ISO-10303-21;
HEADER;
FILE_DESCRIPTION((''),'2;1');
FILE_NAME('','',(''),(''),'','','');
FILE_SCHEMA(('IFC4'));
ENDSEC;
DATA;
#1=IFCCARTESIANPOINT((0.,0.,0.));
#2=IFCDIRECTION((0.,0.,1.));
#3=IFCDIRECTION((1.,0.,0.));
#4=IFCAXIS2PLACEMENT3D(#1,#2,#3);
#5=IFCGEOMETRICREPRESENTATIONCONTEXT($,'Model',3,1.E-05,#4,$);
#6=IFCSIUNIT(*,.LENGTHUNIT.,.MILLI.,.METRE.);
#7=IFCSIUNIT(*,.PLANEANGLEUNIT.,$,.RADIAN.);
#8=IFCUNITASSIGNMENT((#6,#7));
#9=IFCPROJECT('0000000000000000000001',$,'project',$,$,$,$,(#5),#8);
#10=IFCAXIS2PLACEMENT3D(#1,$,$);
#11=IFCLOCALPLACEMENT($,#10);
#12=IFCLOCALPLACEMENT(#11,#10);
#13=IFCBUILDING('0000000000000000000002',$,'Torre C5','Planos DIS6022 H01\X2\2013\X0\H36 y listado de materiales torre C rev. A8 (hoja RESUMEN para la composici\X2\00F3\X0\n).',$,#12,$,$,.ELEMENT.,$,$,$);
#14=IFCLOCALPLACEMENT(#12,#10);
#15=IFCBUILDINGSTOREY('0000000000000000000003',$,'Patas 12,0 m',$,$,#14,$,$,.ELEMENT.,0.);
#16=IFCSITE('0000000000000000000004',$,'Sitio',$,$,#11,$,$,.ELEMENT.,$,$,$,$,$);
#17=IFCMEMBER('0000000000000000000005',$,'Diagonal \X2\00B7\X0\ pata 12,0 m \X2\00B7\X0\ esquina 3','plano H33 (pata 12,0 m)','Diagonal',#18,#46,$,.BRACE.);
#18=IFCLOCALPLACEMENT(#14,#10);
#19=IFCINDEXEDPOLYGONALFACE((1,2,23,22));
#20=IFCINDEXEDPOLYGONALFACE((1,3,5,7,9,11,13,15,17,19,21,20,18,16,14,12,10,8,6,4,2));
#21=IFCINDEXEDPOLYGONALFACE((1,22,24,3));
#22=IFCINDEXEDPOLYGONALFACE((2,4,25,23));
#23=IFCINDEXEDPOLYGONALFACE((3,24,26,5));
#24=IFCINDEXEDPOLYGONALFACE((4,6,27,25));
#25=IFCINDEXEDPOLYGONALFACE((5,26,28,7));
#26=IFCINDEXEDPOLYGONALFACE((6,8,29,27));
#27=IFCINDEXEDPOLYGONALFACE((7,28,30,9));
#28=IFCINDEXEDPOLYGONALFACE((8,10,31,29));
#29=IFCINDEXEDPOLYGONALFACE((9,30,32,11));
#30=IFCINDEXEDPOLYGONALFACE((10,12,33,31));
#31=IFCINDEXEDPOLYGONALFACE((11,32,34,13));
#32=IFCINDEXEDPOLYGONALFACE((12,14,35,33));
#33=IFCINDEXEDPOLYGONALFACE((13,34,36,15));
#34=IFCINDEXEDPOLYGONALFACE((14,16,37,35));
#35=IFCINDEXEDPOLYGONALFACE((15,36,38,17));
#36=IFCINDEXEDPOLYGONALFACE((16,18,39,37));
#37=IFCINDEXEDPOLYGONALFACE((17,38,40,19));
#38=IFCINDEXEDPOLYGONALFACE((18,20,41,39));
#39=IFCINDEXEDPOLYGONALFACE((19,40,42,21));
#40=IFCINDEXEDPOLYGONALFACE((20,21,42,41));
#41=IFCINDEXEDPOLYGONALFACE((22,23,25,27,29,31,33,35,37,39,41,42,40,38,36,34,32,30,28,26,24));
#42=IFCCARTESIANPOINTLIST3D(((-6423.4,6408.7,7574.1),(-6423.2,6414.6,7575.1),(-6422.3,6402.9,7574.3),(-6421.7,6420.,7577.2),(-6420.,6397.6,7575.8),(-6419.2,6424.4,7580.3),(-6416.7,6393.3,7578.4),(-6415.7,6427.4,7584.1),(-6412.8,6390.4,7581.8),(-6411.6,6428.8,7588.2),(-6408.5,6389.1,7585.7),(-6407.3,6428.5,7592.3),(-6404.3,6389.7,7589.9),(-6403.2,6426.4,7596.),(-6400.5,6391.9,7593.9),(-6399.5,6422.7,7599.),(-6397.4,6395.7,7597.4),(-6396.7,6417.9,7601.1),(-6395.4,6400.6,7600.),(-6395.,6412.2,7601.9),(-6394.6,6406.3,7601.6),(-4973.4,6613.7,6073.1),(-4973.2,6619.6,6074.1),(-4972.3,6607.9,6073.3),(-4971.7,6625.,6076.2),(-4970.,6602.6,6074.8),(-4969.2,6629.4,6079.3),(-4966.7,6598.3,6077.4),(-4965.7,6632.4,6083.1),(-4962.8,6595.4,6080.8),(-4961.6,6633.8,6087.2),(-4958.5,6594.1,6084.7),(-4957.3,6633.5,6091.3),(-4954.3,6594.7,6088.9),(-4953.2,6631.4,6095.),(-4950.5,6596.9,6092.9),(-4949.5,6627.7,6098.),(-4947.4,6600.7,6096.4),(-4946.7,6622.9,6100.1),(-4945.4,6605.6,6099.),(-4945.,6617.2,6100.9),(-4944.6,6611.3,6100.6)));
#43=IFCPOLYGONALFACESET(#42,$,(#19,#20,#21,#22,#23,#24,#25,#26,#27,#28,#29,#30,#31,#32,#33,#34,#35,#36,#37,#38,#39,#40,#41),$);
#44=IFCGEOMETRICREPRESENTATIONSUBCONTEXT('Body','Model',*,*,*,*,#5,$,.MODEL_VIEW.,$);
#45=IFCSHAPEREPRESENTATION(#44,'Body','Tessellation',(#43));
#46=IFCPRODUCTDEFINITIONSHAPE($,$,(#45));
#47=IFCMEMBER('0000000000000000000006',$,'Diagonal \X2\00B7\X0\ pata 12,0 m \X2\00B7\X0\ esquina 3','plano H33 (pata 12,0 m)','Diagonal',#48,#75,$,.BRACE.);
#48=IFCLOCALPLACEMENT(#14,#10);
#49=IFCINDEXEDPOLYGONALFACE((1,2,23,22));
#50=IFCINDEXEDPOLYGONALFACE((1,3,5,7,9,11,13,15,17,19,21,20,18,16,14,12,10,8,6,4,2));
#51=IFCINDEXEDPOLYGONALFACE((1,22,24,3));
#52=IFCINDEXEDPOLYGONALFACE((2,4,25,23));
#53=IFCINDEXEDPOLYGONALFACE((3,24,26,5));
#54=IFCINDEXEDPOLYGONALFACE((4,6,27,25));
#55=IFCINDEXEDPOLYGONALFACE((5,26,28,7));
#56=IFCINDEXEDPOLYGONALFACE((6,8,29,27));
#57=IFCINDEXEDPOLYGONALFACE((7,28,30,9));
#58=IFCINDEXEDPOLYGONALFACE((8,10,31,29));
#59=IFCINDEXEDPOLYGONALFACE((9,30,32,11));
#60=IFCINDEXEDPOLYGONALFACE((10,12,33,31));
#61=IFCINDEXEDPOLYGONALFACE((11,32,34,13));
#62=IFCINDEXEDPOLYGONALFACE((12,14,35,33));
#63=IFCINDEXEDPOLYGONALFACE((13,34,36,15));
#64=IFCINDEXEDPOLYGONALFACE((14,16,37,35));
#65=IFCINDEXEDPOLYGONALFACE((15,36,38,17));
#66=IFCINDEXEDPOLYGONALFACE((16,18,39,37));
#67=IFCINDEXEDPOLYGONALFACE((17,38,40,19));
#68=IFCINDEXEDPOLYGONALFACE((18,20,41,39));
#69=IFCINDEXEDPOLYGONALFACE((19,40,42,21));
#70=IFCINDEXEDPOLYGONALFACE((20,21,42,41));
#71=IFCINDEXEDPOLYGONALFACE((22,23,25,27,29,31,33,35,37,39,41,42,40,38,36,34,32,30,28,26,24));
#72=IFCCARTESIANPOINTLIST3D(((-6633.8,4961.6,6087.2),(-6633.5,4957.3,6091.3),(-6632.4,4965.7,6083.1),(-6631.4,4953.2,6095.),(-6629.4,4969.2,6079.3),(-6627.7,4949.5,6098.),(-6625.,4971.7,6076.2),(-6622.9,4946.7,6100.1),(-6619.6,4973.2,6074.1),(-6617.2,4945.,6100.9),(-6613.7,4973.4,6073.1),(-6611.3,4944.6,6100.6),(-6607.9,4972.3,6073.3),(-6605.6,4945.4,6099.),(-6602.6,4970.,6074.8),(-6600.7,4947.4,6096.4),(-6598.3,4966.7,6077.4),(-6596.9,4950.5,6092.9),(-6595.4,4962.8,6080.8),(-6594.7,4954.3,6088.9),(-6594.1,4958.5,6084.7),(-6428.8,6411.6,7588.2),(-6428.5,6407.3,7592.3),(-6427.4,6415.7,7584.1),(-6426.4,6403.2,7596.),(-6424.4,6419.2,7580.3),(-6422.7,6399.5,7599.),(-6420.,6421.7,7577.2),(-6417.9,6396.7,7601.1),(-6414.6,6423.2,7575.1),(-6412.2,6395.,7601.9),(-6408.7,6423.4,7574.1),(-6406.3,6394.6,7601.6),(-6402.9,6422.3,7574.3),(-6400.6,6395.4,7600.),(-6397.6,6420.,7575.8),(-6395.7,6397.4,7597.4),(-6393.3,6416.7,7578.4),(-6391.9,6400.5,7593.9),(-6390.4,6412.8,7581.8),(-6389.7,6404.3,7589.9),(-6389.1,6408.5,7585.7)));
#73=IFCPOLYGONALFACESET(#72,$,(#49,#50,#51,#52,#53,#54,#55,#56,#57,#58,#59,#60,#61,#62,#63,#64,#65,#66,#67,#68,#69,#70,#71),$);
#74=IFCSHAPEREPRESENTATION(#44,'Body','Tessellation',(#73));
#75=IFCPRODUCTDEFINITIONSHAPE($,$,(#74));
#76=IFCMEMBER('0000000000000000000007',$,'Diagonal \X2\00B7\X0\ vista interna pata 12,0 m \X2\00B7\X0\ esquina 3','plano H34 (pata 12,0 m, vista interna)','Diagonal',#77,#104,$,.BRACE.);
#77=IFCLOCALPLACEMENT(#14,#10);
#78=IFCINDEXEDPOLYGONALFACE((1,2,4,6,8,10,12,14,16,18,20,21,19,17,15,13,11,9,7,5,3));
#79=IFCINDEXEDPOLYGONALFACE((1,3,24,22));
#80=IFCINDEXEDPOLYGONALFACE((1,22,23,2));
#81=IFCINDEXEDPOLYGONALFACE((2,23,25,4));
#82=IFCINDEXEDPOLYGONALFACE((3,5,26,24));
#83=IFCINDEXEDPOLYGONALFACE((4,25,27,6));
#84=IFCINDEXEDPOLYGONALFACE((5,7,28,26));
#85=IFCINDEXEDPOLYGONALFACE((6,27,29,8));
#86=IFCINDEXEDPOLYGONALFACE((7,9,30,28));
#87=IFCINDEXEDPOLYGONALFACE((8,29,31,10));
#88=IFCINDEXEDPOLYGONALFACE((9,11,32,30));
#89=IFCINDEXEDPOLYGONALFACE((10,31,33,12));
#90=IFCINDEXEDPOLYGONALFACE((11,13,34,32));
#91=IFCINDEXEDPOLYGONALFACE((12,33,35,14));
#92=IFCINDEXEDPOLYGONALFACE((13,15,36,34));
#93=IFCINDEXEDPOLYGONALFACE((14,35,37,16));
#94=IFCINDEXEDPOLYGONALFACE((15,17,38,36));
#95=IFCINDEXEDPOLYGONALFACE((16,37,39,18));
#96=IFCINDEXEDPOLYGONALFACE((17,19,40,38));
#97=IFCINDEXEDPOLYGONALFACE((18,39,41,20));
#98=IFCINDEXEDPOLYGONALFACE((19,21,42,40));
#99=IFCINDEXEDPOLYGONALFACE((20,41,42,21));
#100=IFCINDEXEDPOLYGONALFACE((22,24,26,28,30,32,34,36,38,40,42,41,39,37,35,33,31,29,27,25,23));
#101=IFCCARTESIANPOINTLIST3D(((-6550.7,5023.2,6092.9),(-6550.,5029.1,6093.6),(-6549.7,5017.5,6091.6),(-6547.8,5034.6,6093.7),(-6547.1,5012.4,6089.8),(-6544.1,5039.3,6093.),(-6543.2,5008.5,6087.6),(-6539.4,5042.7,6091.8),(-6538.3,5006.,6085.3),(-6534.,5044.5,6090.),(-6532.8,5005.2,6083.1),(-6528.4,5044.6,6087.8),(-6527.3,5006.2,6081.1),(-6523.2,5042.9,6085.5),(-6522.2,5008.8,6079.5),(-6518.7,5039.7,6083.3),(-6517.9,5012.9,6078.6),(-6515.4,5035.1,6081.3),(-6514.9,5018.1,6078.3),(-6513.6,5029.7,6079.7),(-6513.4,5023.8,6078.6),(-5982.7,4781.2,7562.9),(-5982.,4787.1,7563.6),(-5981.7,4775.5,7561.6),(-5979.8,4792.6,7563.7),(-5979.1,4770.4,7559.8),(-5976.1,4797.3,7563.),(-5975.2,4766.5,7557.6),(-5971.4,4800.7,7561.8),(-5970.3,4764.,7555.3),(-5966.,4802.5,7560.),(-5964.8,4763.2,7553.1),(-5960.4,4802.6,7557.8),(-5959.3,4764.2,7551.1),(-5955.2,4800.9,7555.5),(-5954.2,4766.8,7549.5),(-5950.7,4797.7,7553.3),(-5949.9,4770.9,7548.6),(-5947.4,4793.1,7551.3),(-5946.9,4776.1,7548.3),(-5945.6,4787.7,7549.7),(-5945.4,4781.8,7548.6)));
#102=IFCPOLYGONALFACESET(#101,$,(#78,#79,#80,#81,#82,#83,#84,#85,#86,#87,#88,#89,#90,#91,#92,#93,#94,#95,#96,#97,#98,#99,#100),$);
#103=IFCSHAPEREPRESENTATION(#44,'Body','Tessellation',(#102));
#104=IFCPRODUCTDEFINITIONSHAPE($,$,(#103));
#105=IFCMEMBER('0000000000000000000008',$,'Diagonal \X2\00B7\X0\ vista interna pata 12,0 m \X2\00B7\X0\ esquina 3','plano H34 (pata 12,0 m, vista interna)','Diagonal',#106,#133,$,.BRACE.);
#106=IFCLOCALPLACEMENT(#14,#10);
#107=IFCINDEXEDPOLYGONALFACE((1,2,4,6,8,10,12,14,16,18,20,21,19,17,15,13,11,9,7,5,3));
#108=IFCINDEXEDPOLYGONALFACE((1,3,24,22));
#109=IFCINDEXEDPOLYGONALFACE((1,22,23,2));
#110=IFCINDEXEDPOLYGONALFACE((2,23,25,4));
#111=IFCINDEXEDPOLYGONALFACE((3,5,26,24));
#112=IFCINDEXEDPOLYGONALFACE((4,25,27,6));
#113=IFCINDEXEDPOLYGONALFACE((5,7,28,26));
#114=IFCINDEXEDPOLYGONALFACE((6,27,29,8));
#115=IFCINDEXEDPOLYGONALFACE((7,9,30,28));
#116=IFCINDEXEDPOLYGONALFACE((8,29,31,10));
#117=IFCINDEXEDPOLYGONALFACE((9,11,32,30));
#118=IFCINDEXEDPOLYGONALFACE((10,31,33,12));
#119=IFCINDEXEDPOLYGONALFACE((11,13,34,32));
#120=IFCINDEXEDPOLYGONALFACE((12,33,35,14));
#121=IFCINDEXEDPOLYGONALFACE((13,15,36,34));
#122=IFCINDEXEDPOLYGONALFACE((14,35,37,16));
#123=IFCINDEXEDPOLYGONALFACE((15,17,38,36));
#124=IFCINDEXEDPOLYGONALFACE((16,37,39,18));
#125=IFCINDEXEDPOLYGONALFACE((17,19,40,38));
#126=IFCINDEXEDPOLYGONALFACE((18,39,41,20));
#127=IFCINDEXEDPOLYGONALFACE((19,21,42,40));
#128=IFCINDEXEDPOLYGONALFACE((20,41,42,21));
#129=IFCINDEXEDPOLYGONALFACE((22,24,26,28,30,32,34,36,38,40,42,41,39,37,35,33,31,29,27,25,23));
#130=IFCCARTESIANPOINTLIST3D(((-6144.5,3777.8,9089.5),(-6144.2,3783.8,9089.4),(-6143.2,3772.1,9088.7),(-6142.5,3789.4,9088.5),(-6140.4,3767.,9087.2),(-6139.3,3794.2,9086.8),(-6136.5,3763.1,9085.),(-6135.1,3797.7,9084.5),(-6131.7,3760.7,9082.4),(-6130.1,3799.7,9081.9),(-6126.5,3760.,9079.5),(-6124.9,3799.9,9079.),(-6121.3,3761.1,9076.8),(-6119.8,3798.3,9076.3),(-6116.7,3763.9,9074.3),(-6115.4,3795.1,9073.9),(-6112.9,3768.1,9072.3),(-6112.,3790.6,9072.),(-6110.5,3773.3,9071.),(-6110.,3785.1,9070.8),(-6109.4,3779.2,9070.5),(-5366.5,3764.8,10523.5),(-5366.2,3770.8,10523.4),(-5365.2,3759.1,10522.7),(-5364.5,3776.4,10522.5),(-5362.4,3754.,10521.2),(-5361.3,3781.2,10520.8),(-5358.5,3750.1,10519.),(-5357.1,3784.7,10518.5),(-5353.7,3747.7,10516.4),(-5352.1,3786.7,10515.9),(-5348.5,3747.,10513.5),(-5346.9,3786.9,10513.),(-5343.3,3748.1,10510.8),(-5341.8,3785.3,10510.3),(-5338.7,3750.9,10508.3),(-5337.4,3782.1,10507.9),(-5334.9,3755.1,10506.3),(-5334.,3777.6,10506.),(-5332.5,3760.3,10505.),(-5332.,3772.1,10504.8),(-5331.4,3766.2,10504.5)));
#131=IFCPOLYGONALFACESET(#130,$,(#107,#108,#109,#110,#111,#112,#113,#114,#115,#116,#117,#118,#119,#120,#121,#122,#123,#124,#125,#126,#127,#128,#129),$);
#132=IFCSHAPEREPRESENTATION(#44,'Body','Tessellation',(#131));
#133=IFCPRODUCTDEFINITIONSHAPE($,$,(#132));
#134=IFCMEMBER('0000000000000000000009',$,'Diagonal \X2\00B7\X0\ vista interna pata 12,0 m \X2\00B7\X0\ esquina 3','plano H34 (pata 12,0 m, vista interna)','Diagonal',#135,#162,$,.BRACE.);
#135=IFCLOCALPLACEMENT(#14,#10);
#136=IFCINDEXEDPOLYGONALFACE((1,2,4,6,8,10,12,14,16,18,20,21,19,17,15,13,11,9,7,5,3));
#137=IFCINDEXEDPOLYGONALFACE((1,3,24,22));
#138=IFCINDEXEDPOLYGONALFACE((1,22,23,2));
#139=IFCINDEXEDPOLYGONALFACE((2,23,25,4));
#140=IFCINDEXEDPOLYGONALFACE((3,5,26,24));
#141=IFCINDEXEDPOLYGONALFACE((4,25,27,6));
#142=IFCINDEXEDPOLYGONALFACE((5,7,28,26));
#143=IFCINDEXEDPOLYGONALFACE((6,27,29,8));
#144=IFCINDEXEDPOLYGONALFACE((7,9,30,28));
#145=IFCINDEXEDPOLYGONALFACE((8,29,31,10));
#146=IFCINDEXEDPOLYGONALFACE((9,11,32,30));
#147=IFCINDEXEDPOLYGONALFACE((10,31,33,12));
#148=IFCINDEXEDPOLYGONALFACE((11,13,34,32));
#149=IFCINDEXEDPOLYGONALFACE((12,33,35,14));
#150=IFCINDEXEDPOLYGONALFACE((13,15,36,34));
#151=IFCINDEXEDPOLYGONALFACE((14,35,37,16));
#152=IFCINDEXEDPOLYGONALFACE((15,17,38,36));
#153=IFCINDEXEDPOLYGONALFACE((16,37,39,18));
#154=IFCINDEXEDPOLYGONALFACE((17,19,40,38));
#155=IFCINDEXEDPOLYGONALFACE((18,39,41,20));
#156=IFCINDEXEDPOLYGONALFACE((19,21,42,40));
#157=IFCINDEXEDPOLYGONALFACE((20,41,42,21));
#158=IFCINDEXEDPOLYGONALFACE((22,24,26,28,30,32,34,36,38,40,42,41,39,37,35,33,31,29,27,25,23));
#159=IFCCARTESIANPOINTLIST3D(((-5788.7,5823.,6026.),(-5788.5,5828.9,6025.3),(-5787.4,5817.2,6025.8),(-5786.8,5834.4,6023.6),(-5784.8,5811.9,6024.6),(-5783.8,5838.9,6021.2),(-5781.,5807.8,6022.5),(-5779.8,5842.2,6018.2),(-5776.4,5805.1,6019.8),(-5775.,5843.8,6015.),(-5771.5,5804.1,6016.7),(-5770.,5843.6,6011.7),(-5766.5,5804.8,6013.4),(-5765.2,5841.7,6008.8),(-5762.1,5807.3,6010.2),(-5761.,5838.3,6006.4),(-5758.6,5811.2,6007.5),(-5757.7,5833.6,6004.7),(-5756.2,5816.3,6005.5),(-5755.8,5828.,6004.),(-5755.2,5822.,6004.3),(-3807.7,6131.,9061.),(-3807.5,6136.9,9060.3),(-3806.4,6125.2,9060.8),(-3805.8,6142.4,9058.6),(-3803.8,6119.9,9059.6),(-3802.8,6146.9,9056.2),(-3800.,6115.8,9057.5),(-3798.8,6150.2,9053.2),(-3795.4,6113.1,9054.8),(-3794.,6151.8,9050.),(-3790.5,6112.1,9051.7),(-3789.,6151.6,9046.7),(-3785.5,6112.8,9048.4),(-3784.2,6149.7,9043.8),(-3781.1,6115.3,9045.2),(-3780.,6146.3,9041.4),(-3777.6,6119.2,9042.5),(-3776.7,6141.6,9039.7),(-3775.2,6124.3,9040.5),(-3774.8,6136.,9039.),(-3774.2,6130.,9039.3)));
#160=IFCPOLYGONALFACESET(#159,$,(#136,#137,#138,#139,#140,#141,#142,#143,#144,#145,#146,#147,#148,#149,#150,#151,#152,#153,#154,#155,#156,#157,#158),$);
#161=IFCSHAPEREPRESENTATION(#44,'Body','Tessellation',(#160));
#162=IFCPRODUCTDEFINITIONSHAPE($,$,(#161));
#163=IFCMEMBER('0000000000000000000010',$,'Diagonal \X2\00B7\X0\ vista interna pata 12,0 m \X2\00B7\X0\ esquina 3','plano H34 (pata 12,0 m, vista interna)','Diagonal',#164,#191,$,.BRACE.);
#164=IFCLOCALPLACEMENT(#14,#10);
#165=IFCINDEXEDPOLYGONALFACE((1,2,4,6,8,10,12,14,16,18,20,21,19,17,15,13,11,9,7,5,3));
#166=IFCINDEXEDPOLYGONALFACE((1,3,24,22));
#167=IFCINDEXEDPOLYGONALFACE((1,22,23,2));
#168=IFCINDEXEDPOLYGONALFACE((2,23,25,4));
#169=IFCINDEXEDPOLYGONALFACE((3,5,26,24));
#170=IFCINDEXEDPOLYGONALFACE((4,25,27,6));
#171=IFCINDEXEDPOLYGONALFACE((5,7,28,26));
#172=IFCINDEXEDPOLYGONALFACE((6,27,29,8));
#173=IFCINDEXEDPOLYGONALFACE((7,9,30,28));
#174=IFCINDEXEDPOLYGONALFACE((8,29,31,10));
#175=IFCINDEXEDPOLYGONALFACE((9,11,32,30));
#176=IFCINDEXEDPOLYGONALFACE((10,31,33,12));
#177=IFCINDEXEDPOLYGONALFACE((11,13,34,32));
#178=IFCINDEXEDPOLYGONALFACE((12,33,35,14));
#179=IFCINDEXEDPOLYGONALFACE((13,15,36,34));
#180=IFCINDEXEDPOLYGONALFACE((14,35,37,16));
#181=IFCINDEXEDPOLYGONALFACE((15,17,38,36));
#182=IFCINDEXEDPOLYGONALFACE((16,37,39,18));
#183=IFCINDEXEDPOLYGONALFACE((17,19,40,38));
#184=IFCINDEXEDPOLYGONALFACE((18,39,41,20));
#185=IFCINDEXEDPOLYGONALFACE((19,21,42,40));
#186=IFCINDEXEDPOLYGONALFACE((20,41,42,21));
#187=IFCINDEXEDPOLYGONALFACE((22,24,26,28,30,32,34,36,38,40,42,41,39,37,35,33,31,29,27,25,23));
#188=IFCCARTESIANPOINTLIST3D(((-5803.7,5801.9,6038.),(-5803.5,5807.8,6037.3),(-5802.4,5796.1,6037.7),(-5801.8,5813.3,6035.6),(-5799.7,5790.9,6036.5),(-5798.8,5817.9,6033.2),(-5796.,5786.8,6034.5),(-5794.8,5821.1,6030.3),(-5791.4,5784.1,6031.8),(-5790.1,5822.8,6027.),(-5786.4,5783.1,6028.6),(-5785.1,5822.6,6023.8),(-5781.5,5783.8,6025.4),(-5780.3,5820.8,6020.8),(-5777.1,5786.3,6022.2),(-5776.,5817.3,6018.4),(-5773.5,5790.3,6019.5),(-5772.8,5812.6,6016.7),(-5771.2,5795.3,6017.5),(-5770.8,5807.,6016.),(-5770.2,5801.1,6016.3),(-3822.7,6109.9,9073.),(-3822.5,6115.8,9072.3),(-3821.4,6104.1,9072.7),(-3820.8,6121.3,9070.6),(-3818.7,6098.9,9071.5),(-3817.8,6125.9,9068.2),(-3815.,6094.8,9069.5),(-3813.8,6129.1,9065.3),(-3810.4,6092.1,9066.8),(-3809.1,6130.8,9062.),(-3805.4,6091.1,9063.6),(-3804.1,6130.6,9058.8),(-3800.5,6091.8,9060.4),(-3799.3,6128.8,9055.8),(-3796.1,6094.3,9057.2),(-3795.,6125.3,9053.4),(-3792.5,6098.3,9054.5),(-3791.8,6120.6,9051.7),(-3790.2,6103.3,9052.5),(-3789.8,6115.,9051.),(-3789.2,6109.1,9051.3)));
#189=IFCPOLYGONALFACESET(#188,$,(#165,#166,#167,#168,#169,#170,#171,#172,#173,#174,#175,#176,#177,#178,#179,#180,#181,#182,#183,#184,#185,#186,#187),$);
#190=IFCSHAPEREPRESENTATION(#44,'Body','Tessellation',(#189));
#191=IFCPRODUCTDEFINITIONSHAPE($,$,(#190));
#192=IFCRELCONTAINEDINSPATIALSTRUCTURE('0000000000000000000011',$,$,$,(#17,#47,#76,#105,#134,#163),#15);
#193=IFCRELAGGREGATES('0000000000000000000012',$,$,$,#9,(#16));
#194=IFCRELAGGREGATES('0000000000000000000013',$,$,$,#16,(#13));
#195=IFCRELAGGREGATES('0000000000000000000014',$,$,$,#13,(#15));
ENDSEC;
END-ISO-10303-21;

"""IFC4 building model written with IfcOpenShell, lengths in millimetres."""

from ifc_helpers import new_model, si_unit, frame, origin, origin_with_axes, place, context, subcontext, project, spatial, circle, extrude, element, save


model = new_model("IFC4")

# Units and contexts
model_context = context("Model", 3, precision=1e-05, world=origin_with_axes())
body_context = subcontext(model_context, "Body", "Model", "MODEL_VIEW")
ifc_project = project(units=[si_unit("LENGTHUNIT", "METRE", prefix="MILLI"), si_unit("PLANEANGLEUNIT", "RADIAN")], contexts=[model_context])

# Site, building, storey
site_placement = place(None, origin())
site = spatial("IfcSite", under=ifc_project, at=site_placement, Name="Sitio", CompositionType="ELEMENT")
building_placement = place(site_placement, origin())
building = spatial("IfcBuilding", under=site, at=building_placement, Name="Torre C5", Description="Planos DIS6022 H01–H36 y listado de materiales torre C rev. A8 (hoja RESUMEN para la composición).", CompositionType="ELEMENT")
storey_placement = place(building_placement, origin())
storey = spatial("IfcBuildingStorey", under=building, at=storey_placement, Name="Patas 12,0 m", CompositionType="ELEMENT", Elevation=0.0)

# Members
for number, where, z_axis, x_axis, name in (
    (1, (-6409.0, 6409.0, 7588.0), (0.691455, 0.097757, -0.715775), (0.42629, -0.855127, 0.295017), "Diagonal · pata 12,0 m · esquina 3"),
    (2, (-6409.0, 6409.0, 7588.0), (-0.097757, -0.691455, -0.715775), (0.855127, -0.42629, 0.295017), "Diagonal · pata 12,0 m · esquina 3"),
):
    element("IfcMember", number, at=place(storey_placement, frame(where, z_axis=z_axis, x_axis=x_axis)), inside=storey, Name=name, Description="plano H33 (pata 12,0 m)", ObjectType="Diagonal", PredefinedType="BRACE", context=body_context, shape_type="SweptSolid", body=[
        extrude(circle(Radius=20.0), None, (0.0, 0.0, 1.0), 2097.0),
    ])
member_1_placement = place(storey_placement, frame((-5964.0, 4783.0, 7556.0), z_axis=(-0.356249, 0.151782, -0.921981), x_axis=(0.704528, -0.604521, -0.371746)))
element("IfcMember", 3, at=member_1_placement, inside=storey, Name="Diagonal · vista interna pata 12,0 m · esquina 3", Description="plano H34 (pata 12,0 m, vista interna)", ObjectType="Diagonal", PredefinedType="BRACE", context=body_context, shape_type="SweptSolid", body=[
    extrude(circle(Radius=20.0), None, (0.0, 0.0, 1.0), 1594.4),
])
member_2_placement = place(storey_placement, frame((-5349.0, 3767.0, 10514.0), z_axis=(-0.47686, 0.007968, -0.878943), x_axis=(0.702989, -0.596812, -0.386809)))
element("IfcMember", 4, at=member_2_placement, inside=storey, Name="Diagonal · vista interna pata 12,0 m · esquina 3", Description="plano H34 (pata 12,0 m, vista interna)", ObjectType="Diagonal", PredefinedType="BRACE", context=body_context, shape_type="SweptSolid", body=[
    extrude(circle(Radius=20.0), None, (0.0, 0.0, 1.0), 1631.5),
])
for number, where, z_axis, x_axis, name in (
    (5, (-3791.0, 6132.0, 9050.0), (-0.544624, -0.084677, -0.834394), (0.494289, -0.836146, -0.237777), "Diagonal · vista interna pata 12,0 m · esquina 3"),
    (6, (-3806.0, 6111.0, 9062.0), (-0.544624, -0.084677, -0.834394), (0.496272, -0.834555, -0.239233), "Diagonal · vista interna pata 12,0 m · esquina 3"),
):
    element("IfcMember", number, at=place(storey_placement, frame(where, z_axis=z_axis, x_axis=x_axis)), inside=storey, Name=name, Description="plano H34 (pata 12,0 m, vista interna)", ObjectType="Diagonal", PredefinedType="BRACE", context=body_context, shape_type="SweptSolid", body=[
        extrude(circle(Radius=20.0), None, (0.0, 0.0, 1.0), 3637.4),
    ])

save(model, "model.ifc")
